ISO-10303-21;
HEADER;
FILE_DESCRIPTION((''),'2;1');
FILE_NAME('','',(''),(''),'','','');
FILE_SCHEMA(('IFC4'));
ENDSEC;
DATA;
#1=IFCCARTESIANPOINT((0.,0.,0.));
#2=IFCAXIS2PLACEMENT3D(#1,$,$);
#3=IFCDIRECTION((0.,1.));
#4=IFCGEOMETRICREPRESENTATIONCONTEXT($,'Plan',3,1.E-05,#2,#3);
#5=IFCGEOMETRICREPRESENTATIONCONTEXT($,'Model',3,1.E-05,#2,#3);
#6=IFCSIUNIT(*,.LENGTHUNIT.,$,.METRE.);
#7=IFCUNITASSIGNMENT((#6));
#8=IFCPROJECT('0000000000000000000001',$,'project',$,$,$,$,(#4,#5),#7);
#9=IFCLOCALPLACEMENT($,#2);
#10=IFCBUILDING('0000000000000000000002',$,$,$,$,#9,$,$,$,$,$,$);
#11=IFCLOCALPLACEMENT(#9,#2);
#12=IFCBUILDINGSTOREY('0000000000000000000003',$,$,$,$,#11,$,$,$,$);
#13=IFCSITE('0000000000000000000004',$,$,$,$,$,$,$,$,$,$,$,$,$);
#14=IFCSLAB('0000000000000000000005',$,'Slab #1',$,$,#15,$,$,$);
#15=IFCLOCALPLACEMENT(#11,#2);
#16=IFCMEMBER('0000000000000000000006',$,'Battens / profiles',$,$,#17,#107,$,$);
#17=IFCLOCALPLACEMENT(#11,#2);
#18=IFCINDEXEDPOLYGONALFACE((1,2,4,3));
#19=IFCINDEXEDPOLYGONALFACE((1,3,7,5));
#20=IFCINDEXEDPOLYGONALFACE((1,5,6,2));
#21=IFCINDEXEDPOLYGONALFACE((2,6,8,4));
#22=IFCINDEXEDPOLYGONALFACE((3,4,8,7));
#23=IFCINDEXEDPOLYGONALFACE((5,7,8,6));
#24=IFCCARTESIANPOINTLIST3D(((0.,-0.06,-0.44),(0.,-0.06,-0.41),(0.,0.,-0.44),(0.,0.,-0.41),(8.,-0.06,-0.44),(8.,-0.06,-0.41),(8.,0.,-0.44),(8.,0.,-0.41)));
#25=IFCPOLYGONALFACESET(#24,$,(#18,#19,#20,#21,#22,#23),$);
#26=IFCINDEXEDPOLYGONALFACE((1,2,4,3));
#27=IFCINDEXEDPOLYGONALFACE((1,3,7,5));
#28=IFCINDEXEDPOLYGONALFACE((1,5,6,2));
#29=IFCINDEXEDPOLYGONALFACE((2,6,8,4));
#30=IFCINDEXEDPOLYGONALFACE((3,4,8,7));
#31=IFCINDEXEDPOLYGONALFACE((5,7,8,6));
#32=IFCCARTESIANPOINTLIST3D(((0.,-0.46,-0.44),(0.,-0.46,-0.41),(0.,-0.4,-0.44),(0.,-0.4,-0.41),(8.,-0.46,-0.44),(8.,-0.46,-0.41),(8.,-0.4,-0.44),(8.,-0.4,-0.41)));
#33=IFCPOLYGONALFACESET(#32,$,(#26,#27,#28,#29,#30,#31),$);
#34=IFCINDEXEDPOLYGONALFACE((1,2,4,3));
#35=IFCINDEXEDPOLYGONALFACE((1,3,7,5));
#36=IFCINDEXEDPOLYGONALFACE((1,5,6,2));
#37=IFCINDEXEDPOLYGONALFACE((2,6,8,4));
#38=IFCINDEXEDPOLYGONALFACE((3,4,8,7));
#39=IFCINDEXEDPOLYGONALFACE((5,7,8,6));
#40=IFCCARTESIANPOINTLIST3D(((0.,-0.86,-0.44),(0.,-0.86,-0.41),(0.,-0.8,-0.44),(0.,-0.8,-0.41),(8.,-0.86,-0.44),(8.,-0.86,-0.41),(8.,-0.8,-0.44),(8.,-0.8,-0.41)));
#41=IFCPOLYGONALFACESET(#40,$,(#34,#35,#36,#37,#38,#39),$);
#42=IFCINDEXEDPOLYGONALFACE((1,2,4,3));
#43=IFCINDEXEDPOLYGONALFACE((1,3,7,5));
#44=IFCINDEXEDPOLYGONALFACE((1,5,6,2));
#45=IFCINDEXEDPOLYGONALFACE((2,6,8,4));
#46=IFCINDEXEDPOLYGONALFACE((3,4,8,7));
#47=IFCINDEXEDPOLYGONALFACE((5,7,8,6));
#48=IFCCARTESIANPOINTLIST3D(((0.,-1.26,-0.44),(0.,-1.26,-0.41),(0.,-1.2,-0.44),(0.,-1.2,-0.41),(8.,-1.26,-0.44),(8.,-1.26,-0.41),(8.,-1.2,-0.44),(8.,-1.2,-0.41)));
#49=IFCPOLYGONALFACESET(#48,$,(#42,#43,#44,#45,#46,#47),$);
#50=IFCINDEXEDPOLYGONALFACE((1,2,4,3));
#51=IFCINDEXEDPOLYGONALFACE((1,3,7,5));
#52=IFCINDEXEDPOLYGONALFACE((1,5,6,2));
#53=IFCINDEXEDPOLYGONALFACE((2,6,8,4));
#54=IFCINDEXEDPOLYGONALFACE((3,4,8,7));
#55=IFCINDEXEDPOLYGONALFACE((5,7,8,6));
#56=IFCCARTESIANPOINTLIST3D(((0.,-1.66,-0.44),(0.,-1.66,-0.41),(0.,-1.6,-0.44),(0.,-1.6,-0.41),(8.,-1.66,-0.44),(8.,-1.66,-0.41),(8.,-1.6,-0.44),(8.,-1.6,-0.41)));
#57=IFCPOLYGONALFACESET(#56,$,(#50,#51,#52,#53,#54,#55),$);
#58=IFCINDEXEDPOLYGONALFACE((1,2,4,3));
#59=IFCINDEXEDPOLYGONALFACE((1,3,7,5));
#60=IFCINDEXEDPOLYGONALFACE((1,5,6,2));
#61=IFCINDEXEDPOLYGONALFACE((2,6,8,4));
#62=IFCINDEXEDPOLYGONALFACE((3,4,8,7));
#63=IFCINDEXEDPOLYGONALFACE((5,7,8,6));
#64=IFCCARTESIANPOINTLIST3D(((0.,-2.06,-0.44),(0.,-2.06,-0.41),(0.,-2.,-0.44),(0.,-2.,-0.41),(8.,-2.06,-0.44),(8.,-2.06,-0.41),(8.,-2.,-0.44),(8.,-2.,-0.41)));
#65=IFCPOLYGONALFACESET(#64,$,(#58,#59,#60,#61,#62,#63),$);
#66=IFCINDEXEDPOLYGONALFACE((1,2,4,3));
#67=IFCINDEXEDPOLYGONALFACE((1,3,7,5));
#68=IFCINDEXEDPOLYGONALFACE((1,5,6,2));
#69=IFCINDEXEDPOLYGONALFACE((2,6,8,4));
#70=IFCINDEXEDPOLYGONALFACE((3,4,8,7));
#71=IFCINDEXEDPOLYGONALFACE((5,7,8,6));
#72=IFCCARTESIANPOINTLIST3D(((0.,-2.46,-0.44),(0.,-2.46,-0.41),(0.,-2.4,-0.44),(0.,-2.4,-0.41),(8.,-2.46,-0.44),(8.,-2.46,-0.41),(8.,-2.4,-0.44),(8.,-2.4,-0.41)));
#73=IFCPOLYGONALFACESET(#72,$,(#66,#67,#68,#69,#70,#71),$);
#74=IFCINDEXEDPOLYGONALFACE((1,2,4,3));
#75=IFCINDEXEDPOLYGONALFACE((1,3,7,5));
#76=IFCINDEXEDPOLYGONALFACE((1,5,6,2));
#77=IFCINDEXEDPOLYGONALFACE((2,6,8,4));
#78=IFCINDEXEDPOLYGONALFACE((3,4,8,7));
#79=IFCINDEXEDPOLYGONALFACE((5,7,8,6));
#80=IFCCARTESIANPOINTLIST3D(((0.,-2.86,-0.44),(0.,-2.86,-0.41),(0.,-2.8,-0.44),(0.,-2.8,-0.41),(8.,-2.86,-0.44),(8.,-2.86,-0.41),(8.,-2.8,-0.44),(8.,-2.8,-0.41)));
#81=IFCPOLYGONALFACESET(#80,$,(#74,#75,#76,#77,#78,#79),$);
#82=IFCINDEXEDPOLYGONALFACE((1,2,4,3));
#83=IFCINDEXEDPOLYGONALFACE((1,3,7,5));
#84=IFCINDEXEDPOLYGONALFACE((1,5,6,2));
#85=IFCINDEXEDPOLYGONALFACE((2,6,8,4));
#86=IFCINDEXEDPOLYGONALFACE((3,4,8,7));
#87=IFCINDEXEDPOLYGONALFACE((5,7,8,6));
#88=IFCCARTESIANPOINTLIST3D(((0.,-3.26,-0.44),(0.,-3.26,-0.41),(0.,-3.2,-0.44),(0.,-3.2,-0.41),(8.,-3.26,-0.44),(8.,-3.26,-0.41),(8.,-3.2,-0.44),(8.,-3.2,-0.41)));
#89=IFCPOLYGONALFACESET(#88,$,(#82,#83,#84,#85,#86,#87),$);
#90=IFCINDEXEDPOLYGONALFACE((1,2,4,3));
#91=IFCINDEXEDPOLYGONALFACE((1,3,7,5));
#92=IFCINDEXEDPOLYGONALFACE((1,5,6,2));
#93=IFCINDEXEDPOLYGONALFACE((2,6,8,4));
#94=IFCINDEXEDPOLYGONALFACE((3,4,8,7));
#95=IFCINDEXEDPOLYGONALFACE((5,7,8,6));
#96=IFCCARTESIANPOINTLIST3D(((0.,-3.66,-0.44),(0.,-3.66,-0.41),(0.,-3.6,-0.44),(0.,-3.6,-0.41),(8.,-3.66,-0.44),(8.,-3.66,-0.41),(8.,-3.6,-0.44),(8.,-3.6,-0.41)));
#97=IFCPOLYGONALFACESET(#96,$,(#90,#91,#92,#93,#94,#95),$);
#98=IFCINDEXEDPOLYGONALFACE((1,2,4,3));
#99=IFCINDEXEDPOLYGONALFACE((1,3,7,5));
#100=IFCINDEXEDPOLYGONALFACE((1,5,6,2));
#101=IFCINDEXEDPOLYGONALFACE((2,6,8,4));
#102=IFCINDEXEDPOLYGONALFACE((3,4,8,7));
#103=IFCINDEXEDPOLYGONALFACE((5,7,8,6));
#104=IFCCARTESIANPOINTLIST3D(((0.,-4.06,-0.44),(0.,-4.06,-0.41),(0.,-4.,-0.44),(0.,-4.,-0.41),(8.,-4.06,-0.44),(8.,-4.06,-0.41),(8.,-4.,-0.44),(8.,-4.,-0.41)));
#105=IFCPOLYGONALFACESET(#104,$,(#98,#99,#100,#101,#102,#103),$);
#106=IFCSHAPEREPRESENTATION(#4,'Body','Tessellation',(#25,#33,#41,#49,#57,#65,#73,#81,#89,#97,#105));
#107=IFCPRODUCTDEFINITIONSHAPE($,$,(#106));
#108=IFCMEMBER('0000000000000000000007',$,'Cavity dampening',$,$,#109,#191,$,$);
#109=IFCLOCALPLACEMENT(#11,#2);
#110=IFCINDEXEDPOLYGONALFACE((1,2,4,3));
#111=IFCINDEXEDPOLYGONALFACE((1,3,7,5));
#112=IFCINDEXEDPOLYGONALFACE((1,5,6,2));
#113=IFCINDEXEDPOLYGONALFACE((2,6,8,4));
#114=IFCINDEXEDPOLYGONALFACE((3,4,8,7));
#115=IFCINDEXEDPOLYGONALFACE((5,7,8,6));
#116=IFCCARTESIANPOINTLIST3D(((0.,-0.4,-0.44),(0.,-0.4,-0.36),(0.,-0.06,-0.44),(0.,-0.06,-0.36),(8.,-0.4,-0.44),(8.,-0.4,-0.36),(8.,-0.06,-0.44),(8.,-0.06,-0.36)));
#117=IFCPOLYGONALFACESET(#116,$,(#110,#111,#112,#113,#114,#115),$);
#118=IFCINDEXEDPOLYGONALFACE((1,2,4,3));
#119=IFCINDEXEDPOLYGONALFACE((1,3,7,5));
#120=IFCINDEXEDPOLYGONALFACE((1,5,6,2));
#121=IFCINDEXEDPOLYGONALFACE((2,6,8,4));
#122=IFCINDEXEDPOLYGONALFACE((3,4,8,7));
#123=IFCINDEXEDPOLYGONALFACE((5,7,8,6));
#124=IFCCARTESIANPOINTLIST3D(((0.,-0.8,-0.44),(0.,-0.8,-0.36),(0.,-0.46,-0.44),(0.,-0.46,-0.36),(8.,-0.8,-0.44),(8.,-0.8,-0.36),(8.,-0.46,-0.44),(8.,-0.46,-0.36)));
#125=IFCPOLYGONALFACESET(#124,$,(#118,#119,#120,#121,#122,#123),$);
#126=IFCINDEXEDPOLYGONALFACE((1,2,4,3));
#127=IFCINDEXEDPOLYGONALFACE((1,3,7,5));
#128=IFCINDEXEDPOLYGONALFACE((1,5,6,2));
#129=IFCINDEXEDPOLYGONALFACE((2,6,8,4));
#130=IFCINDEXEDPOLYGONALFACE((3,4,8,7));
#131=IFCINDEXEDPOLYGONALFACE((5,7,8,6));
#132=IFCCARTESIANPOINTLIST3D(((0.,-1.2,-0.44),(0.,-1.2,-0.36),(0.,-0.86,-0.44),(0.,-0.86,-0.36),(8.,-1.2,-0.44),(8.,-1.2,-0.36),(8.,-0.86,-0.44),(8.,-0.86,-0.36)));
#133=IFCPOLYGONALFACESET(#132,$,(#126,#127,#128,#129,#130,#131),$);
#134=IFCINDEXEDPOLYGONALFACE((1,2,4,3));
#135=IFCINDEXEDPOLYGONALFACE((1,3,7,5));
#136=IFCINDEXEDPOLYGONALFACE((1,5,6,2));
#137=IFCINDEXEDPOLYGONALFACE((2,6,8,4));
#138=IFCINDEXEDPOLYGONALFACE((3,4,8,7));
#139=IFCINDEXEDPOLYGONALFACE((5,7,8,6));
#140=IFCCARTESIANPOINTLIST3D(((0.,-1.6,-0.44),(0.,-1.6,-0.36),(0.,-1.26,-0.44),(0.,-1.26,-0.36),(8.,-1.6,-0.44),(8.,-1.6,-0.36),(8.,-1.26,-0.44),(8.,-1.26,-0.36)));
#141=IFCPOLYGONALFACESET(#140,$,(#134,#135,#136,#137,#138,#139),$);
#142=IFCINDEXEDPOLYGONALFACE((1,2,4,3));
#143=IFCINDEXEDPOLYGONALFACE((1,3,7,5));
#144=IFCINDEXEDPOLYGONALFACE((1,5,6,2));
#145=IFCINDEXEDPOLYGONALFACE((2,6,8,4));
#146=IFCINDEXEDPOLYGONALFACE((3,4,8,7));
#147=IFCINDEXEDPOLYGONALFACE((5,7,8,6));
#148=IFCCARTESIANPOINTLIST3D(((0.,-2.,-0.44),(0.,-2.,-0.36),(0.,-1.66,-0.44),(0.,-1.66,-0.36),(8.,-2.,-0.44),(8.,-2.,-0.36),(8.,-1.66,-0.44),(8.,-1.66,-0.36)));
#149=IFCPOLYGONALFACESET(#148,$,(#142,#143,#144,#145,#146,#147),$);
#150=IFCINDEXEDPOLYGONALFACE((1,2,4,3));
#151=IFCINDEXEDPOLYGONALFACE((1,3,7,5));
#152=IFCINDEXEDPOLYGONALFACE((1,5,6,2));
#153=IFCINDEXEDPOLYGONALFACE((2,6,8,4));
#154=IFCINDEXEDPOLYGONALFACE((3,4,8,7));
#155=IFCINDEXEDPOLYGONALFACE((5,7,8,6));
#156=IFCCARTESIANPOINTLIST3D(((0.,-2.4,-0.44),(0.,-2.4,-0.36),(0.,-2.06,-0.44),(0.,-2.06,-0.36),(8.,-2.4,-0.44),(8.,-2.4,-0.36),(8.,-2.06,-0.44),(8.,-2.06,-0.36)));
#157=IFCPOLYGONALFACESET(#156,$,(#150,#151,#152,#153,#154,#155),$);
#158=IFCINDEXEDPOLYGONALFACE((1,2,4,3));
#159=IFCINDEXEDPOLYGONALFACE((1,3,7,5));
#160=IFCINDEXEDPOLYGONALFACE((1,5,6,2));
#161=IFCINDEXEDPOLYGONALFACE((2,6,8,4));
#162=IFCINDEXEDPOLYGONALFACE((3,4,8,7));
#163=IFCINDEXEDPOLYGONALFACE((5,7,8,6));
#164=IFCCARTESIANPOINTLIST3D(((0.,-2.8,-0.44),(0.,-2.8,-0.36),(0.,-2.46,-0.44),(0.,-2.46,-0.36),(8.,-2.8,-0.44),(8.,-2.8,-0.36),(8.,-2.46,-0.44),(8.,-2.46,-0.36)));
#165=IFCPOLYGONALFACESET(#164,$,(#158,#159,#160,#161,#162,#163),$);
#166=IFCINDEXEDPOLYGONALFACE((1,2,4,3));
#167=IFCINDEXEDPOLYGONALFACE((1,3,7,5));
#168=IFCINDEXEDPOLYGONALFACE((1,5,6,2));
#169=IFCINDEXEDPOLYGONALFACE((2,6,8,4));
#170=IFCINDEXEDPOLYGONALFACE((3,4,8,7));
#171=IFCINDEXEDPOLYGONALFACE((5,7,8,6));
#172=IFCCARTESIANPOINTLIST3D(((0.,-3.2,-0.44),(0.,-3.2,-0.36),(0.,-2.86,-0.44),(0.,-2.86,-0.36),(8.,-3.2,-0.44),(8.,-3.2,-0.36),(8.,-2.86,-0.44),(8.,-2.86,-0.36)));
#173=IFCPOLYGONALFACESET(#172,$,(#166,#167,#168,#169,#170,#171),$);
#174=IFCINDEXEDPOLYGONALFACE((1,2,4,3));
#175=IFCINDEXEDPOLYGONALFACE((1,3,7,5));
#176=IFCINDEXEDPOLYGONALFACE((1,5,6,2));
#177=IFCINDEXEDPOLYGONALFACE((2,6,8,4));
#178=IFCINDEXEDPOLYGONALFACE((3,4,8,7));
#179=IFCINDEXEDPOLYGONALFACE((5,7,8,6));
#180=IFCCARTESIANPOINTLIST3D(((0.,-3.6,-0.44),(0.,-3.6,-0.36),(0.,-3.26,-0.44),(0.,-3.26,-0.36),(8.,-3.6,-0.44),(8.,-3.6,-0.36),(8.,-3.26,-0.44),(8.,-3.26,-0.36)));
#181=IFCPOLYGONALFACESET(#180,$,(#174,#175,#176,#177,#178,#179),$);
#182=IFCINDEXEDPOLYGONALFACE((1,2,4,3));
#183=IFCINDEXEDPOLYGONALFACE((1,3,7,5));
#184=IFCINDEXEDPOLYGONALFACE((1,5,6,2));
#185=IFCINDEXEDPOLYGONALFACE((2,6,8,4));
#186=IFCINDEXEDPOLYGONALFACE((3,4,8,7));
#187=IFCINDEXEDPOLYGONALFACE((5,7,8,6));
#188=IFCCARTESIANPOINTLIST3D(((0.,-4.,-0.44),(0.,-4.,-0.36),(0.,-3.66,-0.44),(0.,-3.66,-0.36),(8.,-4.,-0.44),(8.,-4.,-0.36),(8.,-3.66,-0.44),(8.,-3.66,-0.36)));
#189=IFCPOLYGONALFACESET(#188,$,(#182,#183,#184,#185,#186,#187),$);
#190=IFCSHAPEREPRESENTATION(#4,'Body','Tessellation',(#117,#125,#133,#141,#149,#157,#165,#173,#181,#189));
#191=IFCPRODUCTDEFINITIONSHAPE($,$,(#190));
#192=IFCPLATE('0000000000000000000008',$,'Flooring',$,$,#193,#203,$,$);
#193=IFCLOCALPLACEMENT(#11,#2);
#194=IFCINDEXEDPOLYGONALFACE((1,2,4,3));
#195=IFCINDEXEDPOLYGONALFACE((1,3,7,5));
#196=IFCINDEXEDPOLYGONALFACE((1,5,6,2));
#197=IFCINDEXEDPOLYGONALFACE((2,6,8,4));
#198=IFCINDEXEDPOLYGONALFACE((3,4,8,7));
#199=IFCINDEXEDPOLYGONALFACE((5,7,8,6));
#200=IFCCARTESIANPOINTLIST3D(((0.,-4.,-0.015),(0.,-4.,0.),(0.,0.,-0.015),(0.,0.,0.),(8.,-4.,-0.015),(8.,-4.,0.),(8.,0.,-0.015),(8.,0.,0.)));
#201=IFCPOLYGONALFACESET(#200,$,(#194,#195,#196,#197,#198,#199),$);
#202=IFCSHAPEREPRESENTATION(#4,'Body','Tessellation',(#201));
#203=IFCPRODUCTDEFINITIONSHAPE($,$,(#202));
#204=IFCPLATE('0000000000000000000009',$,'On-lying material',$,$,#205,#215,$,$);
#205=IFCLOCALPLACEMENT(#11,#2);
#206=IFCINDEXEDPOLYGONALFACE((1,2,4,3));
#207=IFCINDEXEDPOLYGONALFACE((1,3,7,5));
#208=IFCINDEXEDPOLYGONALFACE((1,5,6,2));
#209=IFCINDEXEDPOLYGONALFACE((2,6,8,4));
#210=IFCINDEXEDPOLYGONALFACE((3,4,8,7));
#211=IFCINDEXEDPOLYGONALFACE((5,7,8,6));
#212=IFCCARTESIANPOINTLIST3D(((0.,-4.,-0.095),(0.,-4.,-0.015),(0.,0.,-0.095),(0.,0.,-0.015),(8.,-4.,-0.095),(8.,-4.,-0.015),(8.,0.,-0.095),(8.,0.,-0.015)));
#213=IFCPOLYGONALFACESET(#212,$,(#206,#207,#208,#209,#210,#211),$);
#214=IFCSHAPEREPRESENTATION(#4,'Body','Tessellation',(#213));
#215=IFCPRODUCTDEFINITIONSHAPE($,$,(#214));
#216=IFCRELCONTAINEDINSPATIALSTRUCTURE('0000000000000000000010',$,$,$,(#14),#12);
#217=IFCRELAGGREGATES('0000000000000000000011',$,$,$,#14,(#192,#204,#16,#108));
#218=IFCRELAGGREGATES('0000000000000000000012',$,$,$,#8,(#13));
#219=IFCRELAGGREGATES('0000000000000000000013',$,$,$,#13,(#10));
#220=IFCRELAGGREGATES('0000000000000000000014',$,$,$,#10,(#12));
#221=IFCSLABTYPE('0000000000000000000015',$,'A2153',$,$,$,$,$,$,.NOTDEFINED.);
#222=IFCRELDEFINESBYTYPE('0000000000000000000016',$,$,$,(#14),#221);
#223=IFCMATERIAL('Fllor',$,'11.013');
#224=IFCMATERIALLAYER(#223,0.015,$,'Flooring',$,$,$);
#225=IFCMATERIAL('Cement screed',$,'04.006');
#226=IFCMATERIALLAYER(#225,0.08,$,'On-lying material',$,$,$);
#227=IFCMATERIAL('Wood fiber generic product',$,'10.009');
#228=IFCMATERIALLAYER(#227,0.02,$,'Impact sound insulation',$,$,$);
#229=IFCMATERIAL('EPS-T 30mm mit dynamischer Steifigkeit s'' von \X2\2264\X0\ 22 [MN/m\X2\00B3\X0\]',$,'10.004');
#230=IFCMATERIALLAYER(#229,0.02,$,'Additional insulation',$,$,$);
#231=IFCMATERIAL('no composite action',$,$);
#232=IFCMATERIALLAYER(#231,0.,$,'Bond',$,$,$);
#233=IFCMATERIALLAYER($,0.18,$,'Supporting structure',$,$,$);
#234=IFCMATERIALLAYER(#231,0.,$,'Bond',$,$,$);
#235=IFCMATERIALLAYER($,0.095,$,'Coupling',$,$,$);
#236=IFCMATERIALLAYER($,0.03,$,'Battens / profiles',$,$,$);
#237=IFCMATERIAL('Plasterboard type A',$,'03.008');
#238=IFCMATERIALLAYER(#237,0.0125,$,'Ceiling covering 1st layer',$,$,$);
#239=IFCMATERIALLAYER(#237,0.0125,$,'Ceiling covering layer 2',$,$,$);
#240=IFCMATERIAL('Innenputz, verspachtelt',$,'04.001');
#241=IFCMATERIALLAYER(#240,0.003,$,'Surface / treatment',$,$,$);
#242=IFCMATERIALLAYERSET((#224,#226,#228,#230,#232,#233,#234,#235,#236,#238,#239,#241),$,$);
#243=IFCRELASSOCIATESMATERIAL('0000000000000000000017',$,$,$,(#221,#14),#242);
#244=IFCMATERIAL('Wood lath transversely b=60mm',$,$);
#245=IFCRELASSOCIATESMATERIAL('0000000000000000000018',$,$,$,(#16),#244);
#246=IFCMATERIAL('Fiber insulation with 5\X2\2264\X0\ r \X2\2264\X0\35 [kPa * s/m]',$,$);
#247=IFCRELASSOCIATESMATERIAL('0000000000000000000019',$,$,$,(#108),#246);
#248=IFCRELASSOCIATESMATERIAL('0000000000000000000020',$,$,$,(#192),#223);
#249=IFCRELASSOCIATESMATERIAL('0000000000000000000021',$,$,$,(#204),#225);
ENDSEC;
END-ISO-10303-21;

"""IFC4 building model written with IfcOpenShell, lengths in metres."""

from ifc_helpers import new_model, si_unit, direction, frame, frame_2d, origin, origin_with_axes, place, context, project, spatial, rectangle, extrude, material, layer, layer_set, type_object, element, aggregate, save


model = new_model("IFC4")

# Units and contexts
plan_context = context("Plan", 3, precision=1e-05, world=origin(), true_north=direction((0.0, 1.0)))
model_context = context("Model", 3, precision=1e-05, world=origin(), true_north=direction((0.0, 1.0)))
ifc_project = project(units=[si_unit("LENGTHUNIT", "METRE")], contexts=[plan_context, model_context])

# Site, building, storey
site = spatial("IfcSite", under=ifc_project)
building_placement = place(None, origin())
building = spatial("IfcBuilding", under=site, at=building_placement)
storey_placement = place(building_placement, origin())
storey = spatial("IfcBuildingStorey", under=building, at=storey_placement)

# Slab, members, plates
ifc_material_1 = material(Name="Fllor", Category="11.013")
ifc_layer_1 = layer(ifc_material_1, 0.015, Name="Flooring")
ifc_material_2 = material(Name="Cement screed", Category="04.006")
ifc_layer_2 = layer(ifc_material_2, 0.08, Name="On-lying material")
ifc_material_3 = material(Name="Wood fiber generic product", Category="10.009")
ifc_layer_3 = layer(ifc_material_3, 0.02, Name="Impact sound insulation")
ifc_material_4 = material(Name="EPS-T 30mm mit dynamischer Steifigkeit s' von ≤ 22 [MN/m³]", Category="10.004")
ifc_layer_4 = layer(ifc_material_4, 0.02, Name="Additional insulation")
ifc_material_5 = material(Name="no composite action")
ifc_layer_5 = layer(ifc_material_5, 0.0, Name="Bond")
ifc_layer_6 = layer(None, 0.18, Name="Supporting structure")
ifc_layer_7 = layer(ifc_material_5, 0.0, Name="Bond")
ifc_layer_8 = layer(None, 0.095, Name="Coupling")
ifc_layer_9 = layer(None, 0.03, Name="Battens / profiles")
ifc_material_6 = material(Name="Plasterboard type A", Category="03.008")
ifc_layer_10 = layer(ifc_material_6, 0.0125, Name="Ceiling covering 1st layer")
ifc_layer_11 = layer(ifc_material_6, 0.0125, Name="Ceiling covering layer 2")
ifc_material_7 = material(Name="Innenputz, verspachtelt", Category="04.001")
ifc_layer_12 = layer(ifc_material_7, 0.003, Name="Surface / treatment")
ifc_layer_set = layer_set([ifc_layer_1, ifc_layer_2, ifc_layer_3, ifc_layer_4, ifc_layer_5, ifc_layer_6, ifc_layer_7, ifc_layer_8, ifc_layer_9, ifc_layer_10, ifc_layer_11, ifc_layer_12])
slab_type = type_object("IfcSlabType", Name="A2153", PredefinedType="NOTDEFINED", material=ifc_layer_set)
slab_placement = place(None, frame((0.0, 0.0, 0.0), z_axis=(0.0, 0.0, -1.0), x_axis=(1.0, 0.0, 0.0)))
slab = element("IfcSlab", 1, at=slab_placement, inside=storey, type_object=slab_type, material=ifc_layer_set, Name="Slab #1")
ifc_material_8 = material(Name="Wood lath transversely b=60mm")
member_1_placement = place(slab_placement, origin())
member_1 = element("IfcMember", 2, at=member_1_placement, material=ifc_material_8, Name="Battens / profiles", context=plan_context, shape_type="SweptSolid", body=[
    extrude(rectangle(XDim=0.06, YDim=0.03, at=frame_2d((0.03, 0.015), x_axis=(1.0, 0.0))), frame((0.0, 0.0, 0.41), z_axis=(1.0, 0.0, 0.0), x_axis=(0.0, 1.0, 0.0)), (0.0, 0.0, 1.0), 8.0),
    extrude(rectangle(XDim=0.06, YDim=0.03, at=frame_2d((0.03, 0.015), x_axis=(1.0, 0.0))), frame((0.0, 0.4, 0.41), z_axis=(1.0, 0.0, 0.0), x_axis=(0.0, 1.0, 0.0)), (0.0, 0.0, 1.0), 8.0),
    extrude(rectangle(XDim=0.06, YDim=0.03, at=frame_2d((0.03, 0.015), x_axis=(1.0, 0.0))), frame((0.0, 0.8, 0.41), z_axis=(1.0, 0.0, 0.0), x_axis=(0.0, 1.0, 0.0)), (0.0, 0.0, 1.0), 8.0),
    extrude(rectangle(XDim=0.06, YDim=0.03, at=frame_2d((0.03, 0.015), x_axis=(1.0, 0.0))), frame((0.0, 1.2, 0.41), z_axis=(1.0, 0.0, 0.0), x_axis=(0.0, 1.0, 0.0)), (0.0, 0.0, 1.0), 8.0),
    extrude(rectangle(XDim=0.06, YDim=0.03, at=frame_2d((0.03, 0.015), x_axis=(1.0, 0.0))), frame((0.0, 1.6, 0.41), z_axis=(1.0, 0.0, 0.0), x_axis=(0.0, 1.0, 0.0)), (0.0, 0.0, 1.0), 8.0),
    extrude(rectangle(XDim=0.06, YDim=0.03, at=frame_2d((0.03, 0.015), x_axis=(1.0, 0.0))), frame((0.0, 2.0, 0.41), z_axis=(1.0, 0.0, 0.0), x_axis=(0.0, 1.0, 0.0)), (0.0, 0.0, 1.0), 8.0),
    extrude(rectangle(XDim=0.06, YDim=0.03, at=frame_2d((0.03, 0.015), x_axis=(1.0, 0.0))), frame((0.0, 2.4, 0.41), z_axis=(1.0, 0.0, 0.0), x_axis=(0.0, 1.0, 0.0)), (0.0, 0.0, 1.0), 8.0),
    extrude(rectangle(XDim=0.06, YDim=0.03, at=frame_2d((0.03, 0.015), x_axis=(1.0, 0.0))), frame((0.0, 2.8, 0.41), z_axis=(1.0, 0.0, 0.0), x_axis=(0.0, 1.0, 0.0)), (0.0, 0.0, 1.0), 8.0),
    extrude(rectangle(XDim=0.06, YDim=0.03, at=frame_2d((0.03, 0.015), x_axis=(1.0, 0.0))), frame((0.0, 3.2, 0.41), z_axis=(1.0, 0.0, 0.0), x_axis=(0.0, 1.0, 0.0)), (0.0, 0.0, 1.0), 8.0),
    extrude(rectangle(XDim=0.06, YDim=0.03, at=frame_2d((0.03, 0.015), x_axis=(1.0, 0.0))), frame((0.0, 3.6, 0.41), z_axis=(1.0, 0.0, 0.0), x_axis=(0.0, 1.0, 0.0)), (0.0, 0.0, 1.0), 8.0),
    extrude(rectangle(XDim=0.06, YDim=0.03, at=frame_2d((0.03, 0.015), x_axis=(1.0, 0.0))), frame((0.0, 4.0, 0.41), z_axis=(1.0, 0.0, 0.0), x_axis=(0.0, 1.0, 0.0)), (0.0, 0.0, 1.0), 8.0),
])
ifc_material_9 = material(Name="Fiber insulation with 5≤ r ≤35 [kPa * s/m]")
member_2_placement = place(slab_placement, origin())
member_2 = element("IfcMember", 3, at=member_2_placement, material=ifc_material_9, Name="Cavity dampening", context=plan_context, shape_type="SweptSolid", body=[
    extrude(rectangle(XDim=0.34, YDim=0.08, at=frame_2d((0.17, 0.04), x_axis=(1.0, 0.0))), frame((0.0, 0.06, 0.36), z_axis=(1.0, 0.0, 0.0), x_axis=(0.0, 1.0, 0.0)), (0.0, 0.0, 1.0), 8.0),
    extrude(rectangle(XDim=0.34, YDim=0.08, at=frame_2d((0.17, 0.04), x_axis=(1.0, 0.0))), frame((0.0, 0.46, 0.36), z_axis=(1.0, 0.0, 0.0), x_axis=(0.0, 1.0, 0.0)), (0.0, 0.0, 1.0), 8.0),
    extrude(rectangle(XDim=0.34, YDim=0.08, at=frame_2d((0.17, 0.04), x_axis=(1.0, 0.0))), frame((0.0, 0.86, 0.36), z_axis=(1.0, 0.0, 0.0), x_axis=(0.0, 1.0, 0.0)), (0.0, 0.0, 1.0), 8.0),
    extrude(rectangle(XDim=0.34, YDim=0.08, at=frame_2d((0.17, 0.04), x_axis=(1.0, 0.0))), frame((0.0, 1.26, 0.36), z_axis=(1.0, 0.0, 0.0), x_axis=(0.0, 1.0, 0.0)), (0.0, 0.0, 1.0), 8.0),
    extrude(rectangle(XDim=0.34, YDim=0.08, at=frame_2d((0.17, 0.04), x_axis=(1.0, 0.0))), frame((0.0, 1.66, 0.36), z_axis=(1.0, 0.0, 0.0), x_axis=(0.0, 1.0, 0.0)), (0.0, 0.0, 1.0), 8.0),
    extrude(rectangle(XDim=0.34, YDim=0.08, at=frame_2d((0.17, 0.04), x_axis=(1.0, 0.0))), frame((0.0, 2.06, 0.36), z_axis=(1.0, 0.0, 0.0), x_axis=(0.0, 1.0, 0.0)), (0.0, 0.0, 1.0), 8.0),
    extrude(rectangle(XDim=0.34, YDim=0.08, at=frame_2d((0.17, 0.04), x_axis=(1.0, 0.0))), frame((0.0, 2.46, 0.36), z_axis=(1.0, 0.0, 0.0), x_axis=(0.0, 1.0, 0.0)), (0.0, 0.0, 1.0), 8.0),
    extrude(rectangle(XDim=0.34, YDim=0.08, at=frame_2d((0.17, 0.04), x_axis=(1.0, 0.0))), frame((0.0, 2.86, 0.36), z_axis=(1.0, 0.0, 0.0), x_axis=(0.0, 1.0, 0.0)), (0.0, 0.0, 1.0), 8.0),
    extrude(rectangle(XDim=0.34, YDim=0.08, at=frame_2d((0.17, 0.04), x_axis=(1.0, 0.0))), frame((0.0, 3.26, 0.36), z_axis=(1.0, 0.0, 0.0), x_axis=(0.0, 1.0, 0.0)), (0.0, 0.0, 1.0), 8.0),
    extrude(rectangle(XDim=0.34, YDim=0.08, at=frame_2d((0.17, 0.04), x_axis=(1.0, 0.0))), frame((0.0, 3.66, 0.36), z_axis=(1.0, 0.0, 0.0), x_axis=(0.0, 1.0, 0.0)), (0.0, 0.0, 1.0), 8.0),
])
plate_1_placement = place(slab_placement, origin())
plate_1 = element("IfcPlate", 4, at=plate_1_placement, material=ifc_material_1, Name="Flooring", context=plan_context, shape_type="SweptSolid", body=[
    extrude(rectangle(XDim=8.0, YDim=4.0, at=frame_2d((4.0, 2.0), x_axis=(1.0, 0.0))), origin_with_axes(), (0.0, 0.0, 1.0), 0.015),
])
plate_2_placement = place(slab_placement, origin())
plate_2 = element("IfcPlate", 5, at=plate_2_placement, material=ifc_material_2, Name="On-lying material", context=plan_context, shape_type="SweptSolid", body=[
    extrude(rectangle(XDim=8.0, YDim=4.0, at=frame_2d((4.0, 2.0), x_axis=(1.0, 0.0))), frame((0.0, 0.0, 0.015), z_axis=(0.0, 0.0, 1.0), x_axis=(1.0, 0.0, 0.0)), (0.0, 0.0, 1.0), 0.08),
])
aggregate(slab, [plate_1, plate_2, member_1, member_2])

save(model, "model.ifc")
